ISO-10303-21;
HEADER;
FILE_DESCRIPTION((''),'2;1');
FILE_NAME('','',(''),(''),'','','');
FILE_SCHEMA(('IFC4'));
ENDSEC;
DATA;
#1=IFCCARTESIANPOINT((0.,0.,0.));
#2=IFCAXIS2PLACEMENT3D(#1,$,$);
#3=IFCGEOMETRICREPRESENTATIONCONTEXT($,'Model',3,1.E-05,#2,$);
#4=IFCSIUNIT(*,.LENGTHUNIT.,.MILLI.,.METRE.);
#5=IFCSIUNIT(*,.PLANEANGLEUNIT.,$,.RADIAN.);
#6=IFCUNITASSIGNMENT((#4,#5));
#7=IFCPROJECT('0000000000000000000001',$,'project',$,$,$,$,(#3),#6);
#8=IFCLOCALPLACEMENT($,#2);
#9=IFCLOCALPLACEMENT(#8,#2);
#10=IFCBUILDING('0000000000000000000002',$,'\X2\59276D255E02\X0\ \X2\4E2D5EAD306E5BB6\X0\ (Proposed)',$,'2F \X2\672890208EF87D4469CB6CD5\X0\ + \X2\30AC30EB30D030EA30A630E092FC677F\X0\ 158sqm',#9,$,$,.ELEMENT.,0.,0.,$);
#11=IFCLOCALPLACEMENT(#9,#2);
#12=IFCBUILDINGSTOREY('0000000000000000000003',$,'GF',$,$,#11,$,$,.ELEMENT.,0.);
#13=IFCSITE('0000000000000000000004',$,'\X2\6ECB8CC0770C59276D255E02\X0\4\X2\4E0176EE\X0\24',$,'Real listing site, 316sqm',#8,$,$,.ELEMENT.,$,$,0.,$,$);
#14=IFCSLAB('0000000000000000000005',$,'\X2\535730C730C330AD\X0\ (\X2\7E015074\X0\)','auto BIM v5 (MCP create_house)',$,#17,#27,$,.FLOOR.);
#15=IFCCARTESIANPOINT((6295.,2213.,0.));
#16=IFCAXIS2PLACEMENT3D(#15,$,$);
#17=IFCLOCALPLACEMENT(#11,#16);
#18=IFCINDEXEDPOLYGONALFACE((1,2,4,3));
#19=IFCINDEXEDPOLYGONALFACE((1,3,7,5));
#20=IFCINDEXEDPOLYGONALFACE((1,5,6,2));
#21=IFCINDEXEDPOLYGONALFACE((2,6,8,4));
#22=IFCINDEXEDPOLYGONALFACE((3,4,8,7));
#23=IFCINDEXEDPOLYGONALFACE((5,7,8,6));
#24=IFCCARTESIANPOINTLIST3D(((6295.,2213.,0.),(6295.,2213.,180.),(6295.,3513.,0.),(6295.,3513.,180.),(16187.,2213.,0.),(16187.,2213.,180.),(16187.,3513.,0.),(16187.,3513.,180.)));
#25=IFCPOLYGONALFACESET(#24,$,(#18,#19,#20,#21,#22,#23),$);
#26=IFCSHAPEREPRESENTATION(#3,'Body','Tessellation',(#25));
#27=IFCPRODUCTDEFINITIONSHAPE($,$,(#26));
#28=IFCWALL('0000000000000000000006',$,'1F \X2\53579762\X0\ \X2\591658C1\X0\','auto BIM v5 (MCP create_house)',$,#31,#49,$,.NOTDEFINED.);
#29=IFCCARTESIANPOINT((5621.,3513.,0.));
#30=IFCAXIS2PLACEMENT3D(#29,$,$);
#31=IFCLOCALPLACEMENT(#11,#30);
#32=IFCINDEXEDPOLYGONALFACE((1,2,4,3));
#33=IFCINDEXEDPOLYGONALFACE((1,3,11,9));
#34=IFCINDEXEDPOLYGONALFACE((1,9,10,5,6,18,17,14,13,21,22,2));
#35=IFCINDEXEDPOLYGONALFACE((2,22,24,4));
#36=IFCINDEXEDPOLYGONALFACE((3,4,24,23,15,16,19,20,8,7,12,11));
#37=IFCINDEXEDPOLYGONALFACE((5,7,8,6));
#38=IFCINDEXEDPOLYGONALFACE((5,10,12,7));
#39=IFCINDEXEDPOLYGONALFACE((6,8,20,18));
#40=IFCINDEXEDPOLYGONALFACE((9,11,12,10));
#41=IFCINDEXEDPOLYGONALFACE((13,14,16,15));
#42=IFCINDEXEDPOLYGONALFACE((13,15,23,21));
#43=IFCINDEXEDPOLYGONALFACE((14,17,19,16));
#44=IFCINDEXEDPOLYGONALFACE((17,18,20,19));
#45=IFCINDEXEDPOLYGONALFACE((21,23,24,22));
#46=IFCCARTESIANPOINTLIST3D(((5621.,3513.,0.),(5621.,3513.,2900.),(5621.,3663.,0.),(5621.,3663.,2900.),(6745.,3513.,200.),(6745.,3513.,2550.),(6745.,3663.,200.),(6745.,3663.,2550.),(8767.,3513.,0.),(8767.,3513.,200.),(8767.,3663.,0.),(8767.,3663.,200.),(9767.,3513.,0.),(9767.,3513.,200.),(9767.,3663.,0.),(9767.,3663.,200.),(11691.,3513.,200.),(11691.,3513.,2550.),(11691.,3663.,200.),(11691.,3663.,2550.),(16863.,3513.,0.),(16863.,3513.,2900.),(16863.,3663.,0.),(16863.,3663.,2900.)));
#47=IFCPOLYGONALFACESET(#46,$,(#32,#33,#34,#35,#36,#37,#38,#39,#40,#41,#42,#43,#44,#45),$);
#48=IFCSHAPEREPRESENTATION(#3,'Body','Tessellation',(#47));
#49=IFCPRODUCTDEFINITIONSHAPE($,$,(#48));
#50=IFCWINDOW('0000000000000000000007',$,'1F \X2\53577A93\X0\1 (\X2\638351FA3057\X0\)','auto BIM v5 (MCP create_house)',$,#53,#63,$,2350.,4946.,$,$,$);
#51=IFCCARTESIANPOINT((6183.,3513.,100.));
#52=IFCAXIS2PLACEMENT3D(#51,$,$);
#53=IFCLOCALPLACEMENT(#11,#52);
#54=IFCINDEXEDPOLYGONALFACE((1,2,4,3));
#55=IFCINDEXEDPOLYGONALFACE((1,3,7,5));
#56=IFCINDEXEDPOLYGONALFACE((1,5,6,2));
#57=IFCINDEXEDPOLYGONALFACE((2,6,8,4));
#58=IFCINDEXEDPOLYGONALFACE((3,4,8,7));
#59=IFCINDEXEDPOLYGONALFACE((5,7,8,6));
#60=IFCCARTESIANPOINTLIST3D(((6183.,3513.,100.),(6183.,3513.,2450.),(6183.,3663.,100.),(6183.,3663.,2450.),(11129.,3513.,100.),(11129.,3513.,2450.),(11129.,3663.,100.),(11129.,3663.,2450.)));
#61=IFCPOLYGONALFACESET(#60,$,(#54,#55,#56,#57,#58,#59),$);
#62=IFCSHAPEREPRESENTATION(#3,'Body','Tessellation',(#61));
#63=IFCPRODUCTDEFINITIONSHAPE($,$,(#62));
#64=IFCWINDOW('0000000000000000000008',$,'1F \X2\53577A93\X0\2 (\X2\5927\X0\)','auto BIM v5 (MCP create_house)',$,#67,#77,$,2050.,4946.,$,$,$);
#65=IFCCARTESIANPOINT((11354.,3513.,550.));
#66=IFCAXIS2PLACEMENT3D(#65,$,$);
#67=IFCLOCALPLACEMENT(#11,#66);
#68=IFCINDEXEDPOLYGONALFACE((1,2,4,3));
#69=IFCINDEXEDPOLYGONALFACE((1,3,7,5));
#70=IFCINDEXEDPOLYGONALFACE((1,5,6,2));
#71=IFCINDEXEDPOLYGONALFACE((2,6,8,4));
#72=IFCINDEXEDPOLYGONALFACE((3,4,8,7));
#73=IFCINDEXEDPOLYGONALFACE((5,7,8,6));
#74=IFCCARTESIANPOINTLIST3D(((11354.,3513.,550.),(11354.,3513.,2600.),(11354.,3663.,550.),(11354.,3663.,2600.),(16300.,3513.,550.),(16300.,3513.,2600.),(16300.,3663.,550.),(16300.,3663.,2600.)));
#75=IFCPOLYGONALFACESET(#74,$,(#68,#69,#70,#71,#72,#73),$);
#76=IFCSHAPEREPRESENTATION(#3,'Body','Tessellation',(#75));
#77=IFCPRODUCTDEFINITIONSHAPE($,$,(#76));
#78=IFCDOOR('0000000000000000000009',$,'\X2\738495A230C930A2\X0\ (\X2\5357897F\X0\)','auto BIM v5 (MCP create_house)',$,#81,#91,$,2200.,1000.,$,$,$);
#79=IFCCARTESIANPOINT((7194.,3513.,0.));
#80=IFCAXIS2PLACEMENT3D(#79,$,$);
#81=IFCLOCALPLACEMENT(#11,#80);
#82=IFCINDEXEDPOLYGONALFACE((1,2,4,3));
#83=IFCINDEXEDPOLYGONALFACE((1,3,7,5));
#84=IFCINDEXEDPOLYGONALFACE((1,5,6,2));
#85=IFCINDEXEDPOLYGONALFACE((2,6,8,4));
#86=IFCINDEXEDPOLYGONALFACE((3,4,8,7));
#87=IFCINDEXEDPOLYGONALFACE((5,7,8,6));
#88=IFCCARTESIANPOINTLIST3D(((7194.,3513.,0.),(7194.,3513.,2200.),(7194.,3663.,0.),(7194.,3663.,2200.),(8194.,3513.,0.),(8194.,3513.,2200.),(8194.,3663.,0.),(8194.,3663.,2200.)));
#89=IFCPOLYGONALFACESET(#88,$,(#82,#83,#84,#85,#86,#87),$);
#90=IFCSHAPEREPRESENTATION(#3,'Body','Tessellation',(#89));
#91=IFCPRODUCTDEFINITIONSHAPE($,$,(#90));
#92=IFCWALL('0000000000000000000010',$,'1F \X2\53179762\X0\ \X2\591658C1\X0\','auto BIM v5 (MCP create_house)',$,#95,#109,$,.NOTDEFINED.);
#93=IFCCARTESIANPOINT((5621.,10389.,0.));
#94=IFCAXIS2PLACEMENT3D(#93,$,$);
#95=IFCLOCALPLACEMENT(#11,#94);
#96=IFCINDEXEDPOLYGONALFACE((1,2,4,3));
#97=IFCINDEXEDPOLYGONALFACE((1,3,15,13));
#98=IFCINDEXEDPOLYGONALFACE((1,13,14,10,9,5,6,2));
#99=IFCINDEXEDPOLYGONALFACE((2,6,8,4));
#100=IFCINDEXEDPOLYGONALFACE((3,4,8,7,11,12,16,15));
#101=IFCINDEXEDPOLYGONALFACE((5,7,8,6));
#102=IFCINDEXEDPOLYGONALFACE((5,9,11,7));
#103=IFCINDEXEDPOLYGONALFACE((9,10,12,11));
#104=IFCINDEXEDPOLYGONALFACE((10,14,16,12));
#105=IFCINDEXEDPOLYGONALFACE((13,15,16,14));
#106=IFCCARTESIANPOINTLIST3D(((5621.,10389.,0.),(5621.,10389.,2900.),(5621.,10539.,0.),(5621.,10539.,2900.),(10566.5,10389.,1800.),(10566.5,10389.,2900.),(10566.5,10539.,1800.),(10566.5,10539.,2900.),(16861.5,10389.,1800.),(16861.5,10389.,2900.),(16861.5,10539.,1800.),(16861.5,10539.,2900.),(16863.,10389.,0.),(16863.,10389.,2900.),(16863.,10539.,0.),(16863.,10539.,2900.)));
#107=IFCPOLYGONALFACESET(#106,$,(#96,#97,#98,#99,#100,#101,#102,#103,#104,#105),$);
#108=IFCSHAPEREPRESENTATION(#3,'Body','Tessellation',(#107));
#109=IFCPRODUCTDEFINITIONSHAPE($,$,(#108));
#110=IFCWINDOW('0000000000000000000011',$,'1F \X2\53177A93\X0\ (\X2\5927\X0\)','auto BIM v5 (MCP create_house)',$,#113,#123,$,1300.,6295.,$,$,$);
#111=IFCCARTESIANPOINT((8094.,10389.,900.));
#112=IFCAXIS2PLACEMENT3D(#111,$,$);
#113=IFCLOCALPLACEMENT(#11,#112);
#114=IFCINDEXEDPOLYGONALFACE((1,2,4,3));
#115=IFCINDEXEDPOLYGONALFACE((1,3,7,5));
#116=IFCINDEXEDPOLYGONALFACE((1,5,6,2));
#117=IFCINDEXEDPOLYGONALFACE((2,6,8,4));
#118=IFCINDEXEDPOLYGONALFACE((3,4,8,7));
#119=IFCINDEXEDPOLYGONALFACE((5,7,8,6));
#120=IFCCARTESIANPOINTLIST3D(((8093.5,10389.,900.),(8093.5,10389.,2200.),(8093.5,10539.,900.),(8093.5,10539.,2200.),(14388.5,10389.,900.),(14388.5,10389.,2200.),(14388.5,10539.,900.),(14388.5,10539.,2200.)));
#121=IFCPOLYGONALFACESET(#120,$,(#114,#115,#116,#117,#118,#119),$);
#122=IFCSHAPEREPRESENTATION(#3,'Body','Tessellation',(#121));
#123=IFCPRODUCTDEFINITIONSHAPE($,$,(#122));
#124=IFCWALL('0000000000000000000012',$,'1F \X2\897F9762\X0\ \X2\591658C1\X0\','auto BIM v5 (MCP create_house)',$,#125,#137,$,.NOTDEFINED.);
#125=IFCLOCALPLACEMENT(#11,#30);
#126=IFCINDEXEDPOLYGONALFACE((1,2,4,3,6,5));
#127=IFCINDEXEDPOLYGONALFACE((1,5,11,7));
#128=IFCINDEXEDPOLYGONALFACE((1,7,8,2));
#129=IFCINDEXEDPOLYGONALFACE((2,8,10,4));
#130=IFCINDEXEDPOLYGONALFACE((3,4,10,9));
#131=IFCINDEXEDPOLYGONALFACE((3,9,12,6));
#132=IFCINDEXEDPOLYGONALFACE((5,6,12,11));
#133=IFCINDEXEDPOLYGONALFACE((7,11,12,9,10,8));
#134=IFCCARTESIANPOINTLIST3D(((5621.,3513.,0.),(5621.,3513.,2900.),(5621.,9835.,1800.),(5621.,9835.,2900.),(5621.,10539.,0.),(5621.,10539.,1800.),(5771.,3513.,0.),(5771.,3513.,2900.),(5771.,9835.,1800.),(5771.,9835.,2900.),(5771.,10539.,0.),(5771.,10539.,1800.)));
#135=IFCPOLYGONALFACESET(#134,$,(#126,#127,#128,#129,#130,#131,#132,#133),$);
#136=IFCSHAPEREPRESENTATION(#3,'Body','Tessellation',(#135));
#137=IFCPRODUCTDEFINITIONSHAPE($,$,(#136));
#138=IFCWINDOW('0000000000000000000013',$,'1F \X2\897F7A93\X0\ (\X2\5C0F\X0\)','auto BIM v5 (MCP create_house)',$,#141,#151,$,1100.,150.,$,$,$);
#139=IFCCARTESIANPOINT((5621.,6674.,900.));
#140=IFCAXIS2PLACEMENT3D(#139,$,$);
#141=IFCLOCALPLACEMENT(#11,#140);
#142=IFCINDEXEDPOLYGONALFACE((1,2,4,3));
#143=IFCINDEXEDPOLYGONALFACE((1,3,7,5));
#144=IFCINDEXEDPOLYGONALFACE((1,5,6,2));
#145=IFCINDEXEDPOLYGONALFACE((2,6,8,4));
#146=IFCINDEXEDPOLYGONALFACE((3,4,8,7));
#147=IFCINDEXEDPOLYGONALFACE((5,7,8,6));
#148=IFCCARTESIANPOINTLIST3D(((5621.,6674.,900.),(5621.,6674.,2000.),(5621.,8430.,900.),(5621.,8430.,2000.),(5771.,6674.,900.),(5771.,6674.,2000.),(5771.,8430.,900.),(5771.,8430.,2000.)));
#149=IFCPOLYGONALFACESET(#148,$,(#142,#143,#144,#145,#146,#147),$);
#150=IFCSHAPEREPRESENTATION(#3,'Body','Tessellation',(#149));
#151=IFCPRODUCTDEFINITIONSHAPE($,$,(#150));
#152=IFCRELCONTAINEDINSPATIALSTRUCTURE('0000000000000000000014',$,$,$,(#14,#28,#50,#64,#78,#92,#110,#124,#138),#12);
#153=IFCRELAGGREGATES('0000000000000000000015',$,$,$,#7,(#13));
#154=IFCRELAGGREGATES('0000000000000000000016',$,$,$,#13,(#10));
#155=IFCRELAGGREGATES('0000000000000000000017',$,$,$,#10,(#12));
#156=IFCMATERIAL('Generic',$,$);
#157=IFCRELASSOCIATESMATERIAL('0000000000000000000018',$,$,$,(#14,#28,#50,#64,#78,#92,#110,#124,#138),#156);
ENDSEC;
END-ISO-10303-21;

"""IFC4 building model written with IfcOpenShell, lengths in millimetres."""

from ifc_helpers import new_model, si_unit, frame, frame_2d, origin, place, context, project, spatial, rectangle, extrude, material, element, fill, save


model = new_model("IFC4")

# Units and contexts
model_context = context("Model", 3, precision=1e-05, world=origin())
ifc_project = project(units=[si_unit("LENGTHUNIT", "METRE", prefix="MILLI"), si_unit("PLANEANGLEUNIT", "RADIAN")], contexts=[model_context])

# Site, building, storey
site_placement = place(None, origin())
site = spatial("IfcSite", under=ifc_project, at=site_placement, Name="滋賀県大津市4丁目24", ObjectType="Real listing site, 316sqm", CompositionType="ELEMENT", RefElevation=0.0)
building_placement = place(site_placement, origin())
building = spatial("IfcBuilding", under=site, at=building_placement, Name="大津市 中庭の家 (Proposed)", ObjectType="2F 木造軸組構法 + ガルバリウム鋼板 158sqm", CompositionType="ELEMENT", ElevationOfRefHeight=0.0, ElevationOfTerrain=0.0)
storey_placement = place(building_placement, origin())
storey = spatial("IfcBuildingStorey", under=building, at=storey_placement, Name="GF", CompositionType="ELEMENT", Elevation=0.0)

# Slab
ifc_material = material(Name="Generic")
slab_1_placement = place(storey_placement, frame((6295.0, 2213.0, 0.0)))
element("IfcSlab", 1, at=slab_1_placement, inside=storey, material=ifc_material, Name="南デッキ (縁側)", Description="auto BIM v5 (MCP create_house)", PredefinedType="FLOOR", context=model_context, shape_type="SweptSolid", body=[
    extrude(rectangle(XDim=9892.0, YDim=1300.0, at=frame_2d((4946.0, 650.0))), frame((6295.0, 2213.0, 0.0)), (0.0, 0.0, 1.0), 180.0),
])

# Wall, openings, windows, door
wall_1_placement = place(storey_placement, frame((5621.0, 3513.0, 0.0)))
wall_1 = element("IfcWall", 2, at=wall_1_placement, inside=storey, material=ifc_material, Name="1F 南面 外壁", Description="auto BIM v5 (MCP create_house)", PredefinedType="NOTDEFINED", context=model_context, shape_type="SweptSolid", body=[
    extrude(rectangle(XDim=11242.0, YDim=150.0, at=frame_2d((5621.0, 75.0))), frame((5621.0, 3513.0, 0.0)), (0.0, 0.0, 1.0), 2900.0),
])
opening_1_placement = place(storey_placement, frame((6183.0, 3513.0, 100.0)))
opening_1 = element("IfcOpeningElement", 3, at=opening_1_placement, cuts=wall_1, PredefinedType="NOTDEFINED", context=model_context, shape_type="SweptSolid", body=[
    extrude(rectangle(XDim=4946.0, YDim=150.0, at=frame_2d((2473.0, 75.0))), frame((6183.0, 3513.0, 100.0)), (0.0, 0.0, 1.0), 2350.0),
])
opening_2_placement = place(storey_placement, frame((11354.0, 3513.0, 550.0)))
opening_2 = element("IfcOpeningElement", 4, at=opening_2_placement, cuts=wall_1, PredefinedType="NOTDEFINED", context=model_context, shape_type="SweptSolid", body=[
    extrude(rectangle(XDim=4946.0, YDim=150.0, at=frame_2d((2473.0, 75.0))), frame((11354.0, 3513.0, 550.0)), (0.0, 0.0, 1.0), 2050.0),
])
opening_3_placement = place(storey_placement, frame((7194.0, 3513.0, 0.0)))
opening_3 = element("IfcOpeningElement", 5, at=opening_3_placement, cuts=wall_1, PredefinedType="NOTDEFINED", context=model_context, shape_type="SweptSolid", body=[
    extrude(rectangle(XDim=1000.0, YDim=150.0, at=frame_2d((500.0, 75.0))), frame((7194.0, 3513.0, 0.0)), (0.0, 0.0, 1.0), 2200.0),
])
window_1_placement = place(storey_placement, frame((6183.0, 3513.0, 100.0)))
window_1 = element("IfcWindow", 6, at=window_1_placement, inside=storey, material=ifc_material, Name="1F 南窓1 (掃出し)", Description="auto BIM v5 (MCP create_house)", OverallHeight=2350.0, OverallWidth=4946.0, context=model_context, shape_type="SweptSolid", body=[
    extrude(rectangle(XDim=4946.0, YDim=150.0, at=frame_2d((2473.0, 75.0))), frame((6183.0, 3513.0, 100.0)), (0.0, 0.0, 1.0), 2350.0),
])
fill(opening_1, window_1)
window_2_placement = place(storey_placement, frame((11354.0, 3513.0, 550.0)))
window_2 = element("IfcWindow", 7, at=window_2_placement, inside=storey, material=ifc_material, Name="1F 南窓2 (大)", Description="auto BIM v5 (MCP create_house)", OverallHeight=2050.0, OverallWidth=4946.0, context=model_context, shape_type="SweptSolid", body=[
    extrude(rectangle(XDim=4946.0, YDim=150.0, at=frame_2d((2473.0, 75.0))), frame((11354.0, 3513.0, 550.0)), (0.0, 0.0, 1.0), 2050.0),
])
fill(opening_2, window_2)
door_1_placement = place(storey_placement, frame((7194.0, 3513.0, 0.0)))
door_1 = element("IfcDoor", 8, at=door_1_placement, inside=storey, material=ifc_material, Name="玄関ドア (南西)", Description="auto BIM v5 (MCP create_house)", OverallHeight=2200.0, OverallWidth=1000.0, context=model_context, shape_type="SweptSolid", body=[
    extrude(rectangle(XDim=1000.0, YDim=150.0, at=frame_2d((500.0, 75.0))), frame((7194.0, 3513.0, 0.0)), (0.0, 0.0, 1.0), 2200.0),
])
fill(opening_3, door_1)

# Walls, openings, windows
wall_2_placement = place(storey_placement, frame((5621.0, 10389.0, 0.0)))
wall_2 = element("IfcWall", 9, at=wall_2_placement, inside=storey, material=ifc_material, Name="1F 北面 外壁", Description="auto BIM v5 (MCP create_house)", PredefinedType="NOTDEFINED", context=model_context, shape_type="SweptSolid", body=[
    extrude(rectangle(XDim=11242.0, YDim=150.0, at=frame_2d((5621.0, 75.0))), frame((5621.0, 10389.0, 0.0)), (0.0, 0.0, 1.0), 2900.0),
])
opening_4_placement = place(storey_placement, frame((8094.0, 10389.0, 900.0)))
opening_4 = element("IfcOpeningElement", 10, at=opening_4_placement, cuts=wall_2, PredefinedType="NOTDEFINED", context=model_context, shape_type="SweptSolid", body=[
    extrude(rectangle(XDim=6295.0, YDim=150.0, at=frame_2d((3147.0, 75.0))), frame((8094.0, 10389.0, 900.0)), (0.0, 0.0, 1.0), 1300.0),
])
window_3_placement = place(storey_placement, frame((8094.0, 10389.0, 900.0)))
window_3 = element("IfcWindow", 11, at=window_3_placement, inside=storey, material=ifc_material, Name="1F 北窓 (大)", Description="auto BIM v5 (MCP create_house)", OverallHeight=1300.0, OverallWidth=6295.0, context=model_context, shape_type="SweptSolid", body=[
    extrude(rectangle(XDim=6295.0, YDim=150.0, at=frame_2d((3147.0, 75.0))), frame((8094.0, 10389.0, 900.0)), (0.0, 0.0, 1.0), 1300.0),
])
fill(opening_4, window_3)
wall_3_placement = place(storey_placement, frame((5621.0, 3513.0, 0.0)))
wall_3 = element("IfcWall", 12, at=wall_3_placement, inside=storey, material=ifc_material, Name="1F 西面 外壁", Description="auto BIM v5 (MCP create_house)", PredefinedType="NOTDEFINED", context=model_context, shape_type="SweptSolid", body=[
    extrude(rectangle(XDim=150.0, YDim=7026.0, at=frame_2d((75.0, 3513.0))), frame((5621.0, 3513.0, 0.0)), (0.0, 0.0, 1.0), 2900.0),
])
opening_5_placement = place(storey_placement, frame((5621.0, 6674.0, 900.0)))
opening_5 = element("IfcOpeningElement", 13, at=opening_5_placement, cuts=wall_3, PredefinedType="NOTDEFINED", context=model_context, shape_type="SweptSolid", body=[
    extrude(rectangle(XDim=150.0, YDim=1756.0, at=frame_2d((75.0, 878.0))), frame((5621.0, 6674.0, 900.0)), (0.0, 0.0, 1.0), 1100.0),
])
window_4_placement = place(storey_placement, frame((5621.0, 6674.0, 900.0)))
window_4 = element("IfcWindow", 14, at=window_4_placement, inside=storey, material=ifc_material, Name="1F 西窓 (小)", Description="auto BIM v5 (MCP create_house)", OverallHeight=1100.0, OverallWidth=150.0, context=model_context, shape_type="SweptSolid", body=[
    extrude(rectangle(XDim=150.0, YDim=1756.0, at=frame_2d((75.0, 878.0))), frame((5621.0, 6674.0, 900.0)), (0.0, 0.0, 1.0), 1100.0),
])
fill(opening_5, window_4)

save(model, "model.ifc")
